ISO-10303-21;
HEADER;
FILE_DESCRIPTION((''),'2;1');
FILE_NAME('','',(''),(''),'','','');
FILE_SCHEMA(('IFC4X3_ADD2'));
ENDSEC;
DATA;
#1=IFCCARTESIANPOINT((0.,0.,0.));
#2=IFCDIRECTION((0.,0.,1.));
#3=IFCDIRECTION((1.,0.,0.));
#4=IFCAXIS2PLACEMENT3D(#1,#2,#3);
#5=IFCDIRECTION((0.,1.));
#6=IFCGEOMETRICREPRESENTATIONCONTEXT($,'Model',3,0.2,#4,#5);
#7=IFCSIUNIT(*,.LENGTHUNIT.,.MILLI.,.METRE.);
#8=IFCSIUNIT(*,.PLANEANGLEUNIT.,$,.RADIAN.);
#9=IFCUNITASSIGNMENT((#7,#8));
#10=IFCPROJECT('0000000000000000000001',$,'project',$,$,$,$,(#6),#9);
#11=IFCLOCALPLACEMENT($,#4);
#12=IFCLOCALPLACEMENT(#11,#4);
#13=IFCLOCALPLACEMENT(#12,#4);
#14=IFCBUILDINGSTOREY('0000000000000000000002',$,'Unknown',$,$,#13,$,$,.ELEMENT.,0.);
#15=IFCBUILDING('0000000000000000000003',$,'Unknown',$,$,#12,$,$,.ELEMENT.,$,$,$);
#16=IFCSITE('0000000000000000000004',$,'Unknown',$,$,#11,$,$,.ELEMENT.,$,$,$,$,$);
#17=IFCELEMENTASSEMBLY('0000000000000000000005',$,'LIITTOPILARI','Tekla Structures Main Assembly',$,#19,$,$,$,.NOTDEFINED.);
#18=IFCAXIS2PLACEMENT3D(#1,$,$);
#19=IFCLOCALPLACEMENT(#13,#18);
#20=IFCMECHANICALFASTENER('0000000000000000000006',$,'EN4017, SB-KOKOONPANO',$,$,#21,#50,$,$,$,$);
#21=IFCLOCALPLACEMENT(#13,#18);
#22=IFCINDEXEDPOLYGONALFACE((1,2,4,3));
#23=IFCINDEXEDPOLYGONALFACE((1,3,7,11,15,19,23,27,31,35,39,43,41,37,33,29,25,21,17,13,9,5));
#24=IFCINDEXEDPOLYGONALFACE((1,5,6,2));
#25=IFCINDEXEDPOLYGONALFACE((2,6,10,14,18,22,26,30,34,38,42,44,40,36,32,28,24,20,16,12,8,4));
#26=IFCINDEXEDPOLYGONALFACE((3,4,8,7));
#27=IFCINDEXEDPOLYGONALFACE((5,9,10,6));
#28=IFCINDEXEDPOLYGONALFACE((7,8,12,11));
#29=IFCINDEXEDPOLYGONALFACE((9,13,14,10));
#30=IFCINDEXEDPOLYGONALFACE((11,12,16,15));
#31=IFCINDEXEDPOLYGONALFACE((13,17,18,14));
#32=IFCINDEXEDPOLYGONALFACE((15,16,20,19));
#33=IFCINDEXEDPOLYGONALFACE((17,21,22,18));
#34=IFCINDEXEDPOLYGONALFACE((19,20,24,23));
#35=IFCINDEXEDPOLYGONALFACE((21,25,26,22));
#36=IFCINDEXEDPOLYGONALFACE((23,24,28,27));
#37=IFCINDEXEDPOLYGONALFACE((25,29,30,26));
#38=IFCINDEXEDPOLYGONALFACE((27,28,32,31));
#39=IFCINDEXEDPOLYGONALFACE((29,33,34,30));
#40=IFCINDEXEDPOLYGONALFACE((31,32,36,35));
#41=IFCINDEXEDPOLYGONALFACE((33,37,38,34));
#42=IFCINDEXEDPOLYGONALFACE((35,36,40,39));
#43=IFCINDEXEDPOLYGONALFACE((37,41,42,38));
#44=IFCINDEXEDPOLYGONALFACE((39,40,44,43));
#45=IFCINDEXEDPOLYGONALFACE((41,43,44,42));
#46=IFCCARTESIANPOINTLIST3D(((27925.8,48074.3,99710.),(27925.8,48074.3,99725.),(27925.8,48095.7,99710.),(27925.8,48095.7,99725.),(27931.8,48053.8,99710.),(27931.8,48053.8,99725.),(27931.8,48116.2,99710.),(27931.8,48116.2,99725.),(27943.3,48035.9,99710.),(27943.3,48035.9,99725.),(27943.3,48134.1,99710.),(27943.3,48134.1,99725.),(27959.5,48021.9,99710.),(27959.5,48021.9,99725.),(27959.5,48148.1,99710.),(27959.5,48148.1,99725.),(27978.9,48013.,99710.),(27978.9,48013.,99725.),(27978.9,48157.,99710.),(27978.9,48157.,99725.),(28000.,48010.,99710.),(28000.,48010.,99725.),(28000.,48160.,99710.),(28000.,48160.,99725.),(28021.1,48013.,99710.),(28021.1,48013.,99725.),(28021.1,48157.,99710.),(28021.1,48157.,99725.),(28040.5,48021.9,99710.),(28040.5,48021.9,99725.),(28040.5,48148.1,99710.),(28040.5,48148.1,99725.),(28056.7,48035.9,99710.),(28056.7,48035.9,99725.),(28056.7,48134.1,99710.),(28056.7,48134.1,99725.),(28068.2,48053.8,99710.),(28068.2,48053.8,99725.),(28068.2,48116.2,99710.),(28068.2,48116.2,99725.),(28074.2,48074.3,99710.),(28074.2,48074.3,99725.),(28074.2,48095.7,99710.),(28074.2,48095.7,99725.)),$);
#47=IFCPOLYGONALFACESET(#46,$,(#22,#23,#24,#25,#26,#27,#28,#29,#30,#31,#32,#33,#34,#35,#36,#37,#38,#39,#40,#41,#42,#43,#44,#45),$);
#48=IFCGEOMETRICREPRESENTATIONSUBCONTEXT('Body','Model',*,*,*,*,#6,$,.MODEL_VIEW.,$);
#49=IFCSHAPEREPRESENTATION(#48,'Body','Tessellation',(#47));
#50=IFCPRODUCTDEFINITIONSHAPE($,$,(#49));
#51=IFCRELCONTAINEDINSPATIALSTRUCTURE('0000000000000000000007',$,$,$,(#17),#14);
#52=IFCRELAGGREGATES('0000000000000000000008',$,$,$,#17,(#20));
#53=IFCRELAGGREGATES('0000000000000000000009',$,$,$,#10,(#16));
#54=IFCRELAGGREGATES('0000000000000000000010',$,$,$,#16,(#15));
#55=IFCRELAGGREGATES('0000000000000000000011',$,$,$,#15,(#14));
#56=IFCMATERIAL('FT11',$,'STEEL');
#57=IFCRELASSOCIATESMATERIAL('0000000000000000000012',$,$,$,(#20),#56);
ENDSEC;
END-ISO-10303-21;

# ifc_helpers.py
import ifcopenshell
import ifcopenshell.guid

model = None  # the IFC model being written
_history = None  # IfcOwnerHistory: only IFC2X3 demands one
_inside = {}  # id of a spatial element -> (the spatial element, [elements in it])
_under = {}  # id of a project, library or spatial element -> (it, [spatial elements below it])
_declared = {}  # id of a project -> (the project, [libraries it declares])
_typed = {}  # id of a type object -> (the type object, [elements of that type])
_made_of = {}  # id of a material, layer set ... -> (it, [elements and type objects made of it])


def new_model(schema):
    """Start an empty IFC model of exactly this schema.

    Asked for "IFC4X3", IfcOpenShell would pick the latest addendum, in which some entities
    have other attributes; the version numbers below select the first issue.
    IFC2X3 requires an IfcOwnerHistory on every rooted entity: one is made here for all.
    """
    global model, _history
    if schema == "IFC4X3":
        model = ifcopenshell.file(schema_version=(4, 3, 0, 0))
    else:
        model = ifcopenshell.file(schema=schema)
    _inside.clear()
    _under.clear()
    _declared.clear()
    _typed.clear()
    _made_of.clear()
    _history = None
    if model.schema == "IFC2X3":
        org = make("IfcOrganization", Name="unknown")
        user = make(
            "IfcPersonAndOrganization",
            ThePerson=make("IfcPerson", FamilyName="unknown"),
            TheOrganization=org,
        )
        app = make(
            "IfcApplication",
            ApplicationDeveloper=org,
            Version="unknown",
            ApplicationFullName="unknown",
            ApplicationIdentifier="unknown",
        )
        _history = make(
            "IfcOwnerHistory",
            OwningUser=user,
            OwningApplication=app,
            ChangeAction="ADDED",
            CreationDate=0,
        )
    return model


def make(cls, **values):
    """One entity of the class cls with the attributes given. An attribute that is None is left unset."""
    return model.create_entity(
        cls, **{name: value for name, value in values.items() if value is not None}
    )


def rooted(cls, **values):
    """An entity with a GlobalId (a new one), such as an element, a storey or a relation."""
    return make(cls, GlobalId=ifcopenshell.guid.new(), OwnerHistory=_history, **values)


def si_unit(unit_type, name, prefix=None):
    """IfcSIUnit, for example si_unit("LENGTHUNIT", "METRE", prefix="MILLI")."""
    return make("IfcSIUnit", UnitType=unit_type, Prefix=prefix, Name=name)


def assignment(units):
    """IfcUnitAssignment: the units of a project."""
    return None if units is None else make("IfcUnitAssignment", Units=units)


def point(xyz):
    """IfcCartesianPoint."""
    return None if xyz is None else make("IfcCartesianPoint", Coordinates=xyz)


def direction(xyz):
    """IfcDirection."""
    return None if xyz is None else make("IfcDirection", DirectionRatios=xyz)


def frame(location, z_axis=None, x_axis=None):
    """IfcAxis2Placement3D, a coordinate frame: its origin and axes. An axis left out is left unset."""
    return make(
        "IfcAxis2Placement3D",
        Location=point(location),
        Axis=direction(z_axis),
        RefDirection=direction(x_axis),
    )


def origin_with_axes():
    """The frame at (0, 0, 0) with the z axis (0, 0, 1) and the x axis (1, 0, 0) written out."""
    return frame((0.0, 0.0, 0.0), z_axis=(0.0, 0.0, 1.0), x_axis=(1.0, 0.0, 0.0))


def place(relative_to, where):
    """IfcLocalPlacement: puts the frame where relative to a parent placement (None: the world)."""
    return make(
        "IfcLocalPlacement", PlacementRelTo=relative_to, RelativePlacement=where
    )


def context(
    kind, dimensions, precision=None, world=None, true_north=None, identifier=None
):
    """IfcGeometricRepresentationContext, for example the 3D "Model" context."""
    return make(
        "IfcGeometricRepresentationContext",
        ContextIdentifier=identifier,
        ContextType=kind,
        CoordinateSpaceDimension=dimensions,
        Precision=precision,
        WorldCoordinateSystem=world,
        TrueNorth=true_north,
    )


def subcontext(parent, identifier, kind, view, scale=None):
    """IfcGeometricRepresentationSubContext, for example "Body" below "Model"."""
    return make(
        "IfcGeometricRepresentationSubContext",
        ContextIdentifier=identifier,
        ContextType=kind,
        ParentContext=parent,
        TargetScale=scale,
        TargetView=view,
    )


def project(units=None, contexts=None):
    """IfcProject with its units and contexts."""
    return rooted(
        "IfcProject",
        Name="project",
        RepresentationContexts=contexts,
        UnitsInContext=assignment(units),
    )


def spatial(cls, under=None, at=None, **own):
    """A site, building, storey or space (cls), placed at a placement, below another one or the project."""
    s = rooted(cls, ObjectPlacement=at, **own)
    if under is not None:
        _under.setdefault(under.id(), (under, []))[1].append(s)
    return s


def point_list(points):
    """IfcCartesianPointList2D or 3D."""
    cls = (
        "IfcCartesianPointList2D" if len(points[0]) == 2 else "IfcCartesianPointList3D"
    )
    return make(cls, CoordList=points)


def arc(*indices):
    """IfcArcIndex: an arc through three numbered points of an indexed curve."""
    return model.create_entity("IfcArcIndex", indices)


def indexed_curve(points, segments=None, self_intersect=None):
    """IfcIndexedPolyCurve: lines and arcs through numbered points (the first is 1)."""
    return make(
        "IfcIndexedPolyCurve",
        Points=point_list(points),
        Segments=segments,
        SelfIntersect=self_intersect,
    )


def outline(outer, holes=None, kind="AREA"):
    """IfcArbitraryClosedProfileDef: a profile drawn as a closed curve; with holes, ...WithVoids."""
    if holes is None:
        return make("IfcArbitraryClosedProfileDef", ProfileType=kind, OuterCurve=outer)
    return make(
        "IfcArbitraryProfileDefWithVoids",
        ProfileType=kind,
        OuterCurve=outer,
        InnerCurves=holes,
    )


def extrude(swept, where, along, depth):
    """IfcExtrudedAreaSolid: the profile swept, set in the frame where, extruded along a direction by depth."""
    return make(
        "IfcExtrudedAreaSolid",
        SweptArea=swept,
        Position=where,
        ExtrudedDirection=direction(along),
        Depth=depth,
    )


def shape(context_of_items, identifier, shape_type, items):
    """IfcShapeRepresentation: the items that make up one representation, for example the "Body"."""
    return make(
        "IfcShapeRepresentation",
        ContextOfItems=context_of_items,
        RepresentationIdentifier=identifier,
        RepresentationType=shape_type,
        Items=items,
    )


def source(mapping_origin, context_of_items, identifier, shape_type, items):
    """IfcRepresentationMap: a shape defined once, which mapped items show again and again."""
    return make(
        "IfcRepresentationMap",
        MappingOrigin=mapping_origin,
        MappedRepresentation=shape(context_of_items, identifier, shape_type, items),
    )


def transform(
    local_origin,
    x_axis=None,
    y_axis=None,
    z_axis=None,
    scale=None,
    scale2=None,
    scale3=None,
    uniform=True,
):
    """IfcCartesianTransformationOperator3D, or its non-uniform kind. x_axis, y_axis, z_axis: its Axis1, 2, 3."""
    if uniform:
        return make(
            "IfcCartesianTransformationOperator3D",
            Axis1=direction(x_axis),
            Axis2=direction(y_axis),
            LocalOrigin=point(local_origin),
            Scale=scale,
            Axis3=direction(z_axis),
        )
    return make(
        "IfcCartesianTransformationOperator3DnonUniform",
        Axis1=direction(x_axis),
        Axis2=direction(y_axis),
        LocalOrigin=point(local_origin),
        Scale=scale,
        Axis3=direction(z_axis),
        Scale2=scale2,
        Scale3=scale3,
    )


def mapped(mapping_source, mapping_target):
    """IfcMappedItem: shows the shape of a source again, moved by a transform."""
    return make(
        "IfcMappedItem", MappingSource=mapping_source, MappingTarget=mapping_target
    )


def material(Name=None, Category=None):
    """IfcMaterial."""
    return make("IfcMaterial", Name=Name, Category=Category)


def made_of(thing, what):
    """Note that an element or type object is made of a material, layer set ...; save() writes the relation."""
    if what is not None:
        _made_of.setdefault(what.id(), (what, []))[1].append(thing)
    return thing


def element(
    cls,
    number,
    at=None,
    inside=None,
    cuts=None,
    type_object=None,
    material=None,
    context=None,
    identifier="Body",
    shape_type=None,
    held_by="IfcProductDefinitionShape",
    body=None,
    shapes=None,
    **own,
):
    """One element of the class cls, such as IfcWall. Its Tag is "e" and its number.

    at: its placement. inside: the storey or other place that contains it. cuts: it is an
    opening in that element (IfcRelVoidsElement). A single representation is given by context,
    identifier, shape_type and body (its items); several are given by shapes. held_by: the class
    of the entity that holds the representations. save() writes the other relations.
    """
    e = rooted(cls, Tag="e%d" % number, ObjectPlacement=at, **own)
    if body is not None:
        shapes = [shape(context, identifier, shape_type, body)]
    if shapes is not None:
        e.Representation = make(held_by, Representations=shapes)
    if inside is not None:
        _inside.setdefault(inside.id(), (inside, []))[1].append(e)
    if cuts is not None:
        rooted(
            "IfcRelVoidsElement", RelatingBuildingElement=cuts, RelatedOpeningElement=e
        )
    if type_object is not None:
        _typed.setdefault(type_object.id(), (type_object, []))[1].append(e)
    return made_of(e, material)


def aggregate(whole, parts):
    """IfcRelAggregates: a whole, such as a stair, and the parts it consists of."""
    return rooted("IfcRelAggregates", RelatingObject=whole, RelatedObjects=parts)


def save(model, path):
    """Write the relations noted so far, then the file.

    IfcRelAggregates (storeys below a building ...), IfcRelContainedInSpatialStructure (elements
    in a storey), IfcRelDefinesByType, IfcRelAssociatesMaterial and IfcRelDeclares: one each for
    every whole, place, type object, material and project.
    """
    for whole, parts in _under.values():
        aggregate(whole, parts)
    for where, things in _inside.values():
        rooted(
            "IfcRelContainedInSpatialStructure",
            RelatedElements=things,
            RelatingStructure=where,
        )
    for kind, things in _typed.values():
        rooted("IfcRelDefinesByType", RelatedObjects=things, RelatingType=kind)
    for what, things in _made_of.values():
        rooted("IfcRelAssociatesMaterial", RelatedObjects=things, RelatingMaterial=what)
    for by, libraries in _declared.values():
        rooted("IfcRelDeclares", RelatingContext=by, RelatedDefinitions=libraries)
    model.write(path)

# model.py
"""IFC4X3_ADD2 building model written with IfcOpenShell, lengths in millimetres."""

from ifc_helpers import new_model, si_unit, direction, frame, origin_with_axes, place, context, subcontext, project, spatial, arc, indexed_curve, outline, extrude, source, transform, mapped, material, element, aggregate, save


model = new_model("IFC4X3_ADD2")

# Units and contexts
model_context = context("Model", 3, precision=0.2, world=origin_with_axes(), true_north=direction((0.0, 1.0)))
body_context = subcontext(model_context, "Body", "Model", "MODEL_VIEW")
ifc_project = project(units=[si_unit("LENGTHUNIT", "METRE", prefix="MILLI"), si_unit("PLANEANGLEUNIT", "RADIAN")], contexts=[model_context])

# Site, building, storey
site_placement = place(None, origin_with_axes())
site = spatial("IfcSite", under=ifc_project, at=site_placement, Name="Unknown", CompositionType="ELEMENT")
building_placement = place(site_placement, origin_with_axes())
building = spatial("IfcBuilding", under=site, at=building_placement, Name="Unknown", CompositionType="ELEMENT")
storey_placement = place(building_placement, origin_with_axes())
storey = spatial("IfcBuildingStorey", under=building, at=storey_placement, Name="Unknown", CompositionType="ELEMENT", Elevation=0.0)

# Element assembly
assembly_1_placement = place(storey_placement, frame((28000.0, 48085.0, 87950.0), z_axis=(-1.0, 0.0, 0.0), x_axis=(0.0, 0.0, 1.0)))
assembly_1 = element("IfcElementAssembly", 1, at=assembly_1_placement, inside=storey, Name="LIITTOPILARI", Description="Tekla Structures Main Assembly", PredefinedType="NOTDEFINED")

# Mechanical fastener
ifc_material_1 = material(Name="FT11", Category="STEEL")
shared_shape_1 = source(origin_with_axes(), body_context, "Body", "SweptSolid", [
    extrude(outline(indexed_curve([(75.0, 0.0), (0.0, 75.0), (-75.0, 0.0), (0.0, -75.0)], segments=[arc(1, 2, 3), arc(3, 4, 1)])), frame((0.0, 0.0, 15.0), z_axis=(0.0, 0.0, -1.0), x_axis=(0.0, 1.0, 0.0)), (0.0, 0.0, 1.0), 15.0),
])
mechanical_fastener_1_placement = place(assembly_1_placement, frame((11760.0, 0.0, 0.0), z_axis=(1.0, 0.0, 0.0), x_axis=(0.0, 0.0, -1.0)))
mechanical_fastener_1 = element("IfcMechanicalFastener", 2, at=mechanical_fastener_1_placement, material=ifc_material_1, Name="EN4017, SB-KOKOONPANO", context=body_context, shape_type="MappedRepresentation", body=[
    mapped(shared_shape_1, transform((0.0, 0.0, 0.0))),
])

aggregate(assembly_1, [mechanical_fastener_1])

save(model, "model.ifc")
